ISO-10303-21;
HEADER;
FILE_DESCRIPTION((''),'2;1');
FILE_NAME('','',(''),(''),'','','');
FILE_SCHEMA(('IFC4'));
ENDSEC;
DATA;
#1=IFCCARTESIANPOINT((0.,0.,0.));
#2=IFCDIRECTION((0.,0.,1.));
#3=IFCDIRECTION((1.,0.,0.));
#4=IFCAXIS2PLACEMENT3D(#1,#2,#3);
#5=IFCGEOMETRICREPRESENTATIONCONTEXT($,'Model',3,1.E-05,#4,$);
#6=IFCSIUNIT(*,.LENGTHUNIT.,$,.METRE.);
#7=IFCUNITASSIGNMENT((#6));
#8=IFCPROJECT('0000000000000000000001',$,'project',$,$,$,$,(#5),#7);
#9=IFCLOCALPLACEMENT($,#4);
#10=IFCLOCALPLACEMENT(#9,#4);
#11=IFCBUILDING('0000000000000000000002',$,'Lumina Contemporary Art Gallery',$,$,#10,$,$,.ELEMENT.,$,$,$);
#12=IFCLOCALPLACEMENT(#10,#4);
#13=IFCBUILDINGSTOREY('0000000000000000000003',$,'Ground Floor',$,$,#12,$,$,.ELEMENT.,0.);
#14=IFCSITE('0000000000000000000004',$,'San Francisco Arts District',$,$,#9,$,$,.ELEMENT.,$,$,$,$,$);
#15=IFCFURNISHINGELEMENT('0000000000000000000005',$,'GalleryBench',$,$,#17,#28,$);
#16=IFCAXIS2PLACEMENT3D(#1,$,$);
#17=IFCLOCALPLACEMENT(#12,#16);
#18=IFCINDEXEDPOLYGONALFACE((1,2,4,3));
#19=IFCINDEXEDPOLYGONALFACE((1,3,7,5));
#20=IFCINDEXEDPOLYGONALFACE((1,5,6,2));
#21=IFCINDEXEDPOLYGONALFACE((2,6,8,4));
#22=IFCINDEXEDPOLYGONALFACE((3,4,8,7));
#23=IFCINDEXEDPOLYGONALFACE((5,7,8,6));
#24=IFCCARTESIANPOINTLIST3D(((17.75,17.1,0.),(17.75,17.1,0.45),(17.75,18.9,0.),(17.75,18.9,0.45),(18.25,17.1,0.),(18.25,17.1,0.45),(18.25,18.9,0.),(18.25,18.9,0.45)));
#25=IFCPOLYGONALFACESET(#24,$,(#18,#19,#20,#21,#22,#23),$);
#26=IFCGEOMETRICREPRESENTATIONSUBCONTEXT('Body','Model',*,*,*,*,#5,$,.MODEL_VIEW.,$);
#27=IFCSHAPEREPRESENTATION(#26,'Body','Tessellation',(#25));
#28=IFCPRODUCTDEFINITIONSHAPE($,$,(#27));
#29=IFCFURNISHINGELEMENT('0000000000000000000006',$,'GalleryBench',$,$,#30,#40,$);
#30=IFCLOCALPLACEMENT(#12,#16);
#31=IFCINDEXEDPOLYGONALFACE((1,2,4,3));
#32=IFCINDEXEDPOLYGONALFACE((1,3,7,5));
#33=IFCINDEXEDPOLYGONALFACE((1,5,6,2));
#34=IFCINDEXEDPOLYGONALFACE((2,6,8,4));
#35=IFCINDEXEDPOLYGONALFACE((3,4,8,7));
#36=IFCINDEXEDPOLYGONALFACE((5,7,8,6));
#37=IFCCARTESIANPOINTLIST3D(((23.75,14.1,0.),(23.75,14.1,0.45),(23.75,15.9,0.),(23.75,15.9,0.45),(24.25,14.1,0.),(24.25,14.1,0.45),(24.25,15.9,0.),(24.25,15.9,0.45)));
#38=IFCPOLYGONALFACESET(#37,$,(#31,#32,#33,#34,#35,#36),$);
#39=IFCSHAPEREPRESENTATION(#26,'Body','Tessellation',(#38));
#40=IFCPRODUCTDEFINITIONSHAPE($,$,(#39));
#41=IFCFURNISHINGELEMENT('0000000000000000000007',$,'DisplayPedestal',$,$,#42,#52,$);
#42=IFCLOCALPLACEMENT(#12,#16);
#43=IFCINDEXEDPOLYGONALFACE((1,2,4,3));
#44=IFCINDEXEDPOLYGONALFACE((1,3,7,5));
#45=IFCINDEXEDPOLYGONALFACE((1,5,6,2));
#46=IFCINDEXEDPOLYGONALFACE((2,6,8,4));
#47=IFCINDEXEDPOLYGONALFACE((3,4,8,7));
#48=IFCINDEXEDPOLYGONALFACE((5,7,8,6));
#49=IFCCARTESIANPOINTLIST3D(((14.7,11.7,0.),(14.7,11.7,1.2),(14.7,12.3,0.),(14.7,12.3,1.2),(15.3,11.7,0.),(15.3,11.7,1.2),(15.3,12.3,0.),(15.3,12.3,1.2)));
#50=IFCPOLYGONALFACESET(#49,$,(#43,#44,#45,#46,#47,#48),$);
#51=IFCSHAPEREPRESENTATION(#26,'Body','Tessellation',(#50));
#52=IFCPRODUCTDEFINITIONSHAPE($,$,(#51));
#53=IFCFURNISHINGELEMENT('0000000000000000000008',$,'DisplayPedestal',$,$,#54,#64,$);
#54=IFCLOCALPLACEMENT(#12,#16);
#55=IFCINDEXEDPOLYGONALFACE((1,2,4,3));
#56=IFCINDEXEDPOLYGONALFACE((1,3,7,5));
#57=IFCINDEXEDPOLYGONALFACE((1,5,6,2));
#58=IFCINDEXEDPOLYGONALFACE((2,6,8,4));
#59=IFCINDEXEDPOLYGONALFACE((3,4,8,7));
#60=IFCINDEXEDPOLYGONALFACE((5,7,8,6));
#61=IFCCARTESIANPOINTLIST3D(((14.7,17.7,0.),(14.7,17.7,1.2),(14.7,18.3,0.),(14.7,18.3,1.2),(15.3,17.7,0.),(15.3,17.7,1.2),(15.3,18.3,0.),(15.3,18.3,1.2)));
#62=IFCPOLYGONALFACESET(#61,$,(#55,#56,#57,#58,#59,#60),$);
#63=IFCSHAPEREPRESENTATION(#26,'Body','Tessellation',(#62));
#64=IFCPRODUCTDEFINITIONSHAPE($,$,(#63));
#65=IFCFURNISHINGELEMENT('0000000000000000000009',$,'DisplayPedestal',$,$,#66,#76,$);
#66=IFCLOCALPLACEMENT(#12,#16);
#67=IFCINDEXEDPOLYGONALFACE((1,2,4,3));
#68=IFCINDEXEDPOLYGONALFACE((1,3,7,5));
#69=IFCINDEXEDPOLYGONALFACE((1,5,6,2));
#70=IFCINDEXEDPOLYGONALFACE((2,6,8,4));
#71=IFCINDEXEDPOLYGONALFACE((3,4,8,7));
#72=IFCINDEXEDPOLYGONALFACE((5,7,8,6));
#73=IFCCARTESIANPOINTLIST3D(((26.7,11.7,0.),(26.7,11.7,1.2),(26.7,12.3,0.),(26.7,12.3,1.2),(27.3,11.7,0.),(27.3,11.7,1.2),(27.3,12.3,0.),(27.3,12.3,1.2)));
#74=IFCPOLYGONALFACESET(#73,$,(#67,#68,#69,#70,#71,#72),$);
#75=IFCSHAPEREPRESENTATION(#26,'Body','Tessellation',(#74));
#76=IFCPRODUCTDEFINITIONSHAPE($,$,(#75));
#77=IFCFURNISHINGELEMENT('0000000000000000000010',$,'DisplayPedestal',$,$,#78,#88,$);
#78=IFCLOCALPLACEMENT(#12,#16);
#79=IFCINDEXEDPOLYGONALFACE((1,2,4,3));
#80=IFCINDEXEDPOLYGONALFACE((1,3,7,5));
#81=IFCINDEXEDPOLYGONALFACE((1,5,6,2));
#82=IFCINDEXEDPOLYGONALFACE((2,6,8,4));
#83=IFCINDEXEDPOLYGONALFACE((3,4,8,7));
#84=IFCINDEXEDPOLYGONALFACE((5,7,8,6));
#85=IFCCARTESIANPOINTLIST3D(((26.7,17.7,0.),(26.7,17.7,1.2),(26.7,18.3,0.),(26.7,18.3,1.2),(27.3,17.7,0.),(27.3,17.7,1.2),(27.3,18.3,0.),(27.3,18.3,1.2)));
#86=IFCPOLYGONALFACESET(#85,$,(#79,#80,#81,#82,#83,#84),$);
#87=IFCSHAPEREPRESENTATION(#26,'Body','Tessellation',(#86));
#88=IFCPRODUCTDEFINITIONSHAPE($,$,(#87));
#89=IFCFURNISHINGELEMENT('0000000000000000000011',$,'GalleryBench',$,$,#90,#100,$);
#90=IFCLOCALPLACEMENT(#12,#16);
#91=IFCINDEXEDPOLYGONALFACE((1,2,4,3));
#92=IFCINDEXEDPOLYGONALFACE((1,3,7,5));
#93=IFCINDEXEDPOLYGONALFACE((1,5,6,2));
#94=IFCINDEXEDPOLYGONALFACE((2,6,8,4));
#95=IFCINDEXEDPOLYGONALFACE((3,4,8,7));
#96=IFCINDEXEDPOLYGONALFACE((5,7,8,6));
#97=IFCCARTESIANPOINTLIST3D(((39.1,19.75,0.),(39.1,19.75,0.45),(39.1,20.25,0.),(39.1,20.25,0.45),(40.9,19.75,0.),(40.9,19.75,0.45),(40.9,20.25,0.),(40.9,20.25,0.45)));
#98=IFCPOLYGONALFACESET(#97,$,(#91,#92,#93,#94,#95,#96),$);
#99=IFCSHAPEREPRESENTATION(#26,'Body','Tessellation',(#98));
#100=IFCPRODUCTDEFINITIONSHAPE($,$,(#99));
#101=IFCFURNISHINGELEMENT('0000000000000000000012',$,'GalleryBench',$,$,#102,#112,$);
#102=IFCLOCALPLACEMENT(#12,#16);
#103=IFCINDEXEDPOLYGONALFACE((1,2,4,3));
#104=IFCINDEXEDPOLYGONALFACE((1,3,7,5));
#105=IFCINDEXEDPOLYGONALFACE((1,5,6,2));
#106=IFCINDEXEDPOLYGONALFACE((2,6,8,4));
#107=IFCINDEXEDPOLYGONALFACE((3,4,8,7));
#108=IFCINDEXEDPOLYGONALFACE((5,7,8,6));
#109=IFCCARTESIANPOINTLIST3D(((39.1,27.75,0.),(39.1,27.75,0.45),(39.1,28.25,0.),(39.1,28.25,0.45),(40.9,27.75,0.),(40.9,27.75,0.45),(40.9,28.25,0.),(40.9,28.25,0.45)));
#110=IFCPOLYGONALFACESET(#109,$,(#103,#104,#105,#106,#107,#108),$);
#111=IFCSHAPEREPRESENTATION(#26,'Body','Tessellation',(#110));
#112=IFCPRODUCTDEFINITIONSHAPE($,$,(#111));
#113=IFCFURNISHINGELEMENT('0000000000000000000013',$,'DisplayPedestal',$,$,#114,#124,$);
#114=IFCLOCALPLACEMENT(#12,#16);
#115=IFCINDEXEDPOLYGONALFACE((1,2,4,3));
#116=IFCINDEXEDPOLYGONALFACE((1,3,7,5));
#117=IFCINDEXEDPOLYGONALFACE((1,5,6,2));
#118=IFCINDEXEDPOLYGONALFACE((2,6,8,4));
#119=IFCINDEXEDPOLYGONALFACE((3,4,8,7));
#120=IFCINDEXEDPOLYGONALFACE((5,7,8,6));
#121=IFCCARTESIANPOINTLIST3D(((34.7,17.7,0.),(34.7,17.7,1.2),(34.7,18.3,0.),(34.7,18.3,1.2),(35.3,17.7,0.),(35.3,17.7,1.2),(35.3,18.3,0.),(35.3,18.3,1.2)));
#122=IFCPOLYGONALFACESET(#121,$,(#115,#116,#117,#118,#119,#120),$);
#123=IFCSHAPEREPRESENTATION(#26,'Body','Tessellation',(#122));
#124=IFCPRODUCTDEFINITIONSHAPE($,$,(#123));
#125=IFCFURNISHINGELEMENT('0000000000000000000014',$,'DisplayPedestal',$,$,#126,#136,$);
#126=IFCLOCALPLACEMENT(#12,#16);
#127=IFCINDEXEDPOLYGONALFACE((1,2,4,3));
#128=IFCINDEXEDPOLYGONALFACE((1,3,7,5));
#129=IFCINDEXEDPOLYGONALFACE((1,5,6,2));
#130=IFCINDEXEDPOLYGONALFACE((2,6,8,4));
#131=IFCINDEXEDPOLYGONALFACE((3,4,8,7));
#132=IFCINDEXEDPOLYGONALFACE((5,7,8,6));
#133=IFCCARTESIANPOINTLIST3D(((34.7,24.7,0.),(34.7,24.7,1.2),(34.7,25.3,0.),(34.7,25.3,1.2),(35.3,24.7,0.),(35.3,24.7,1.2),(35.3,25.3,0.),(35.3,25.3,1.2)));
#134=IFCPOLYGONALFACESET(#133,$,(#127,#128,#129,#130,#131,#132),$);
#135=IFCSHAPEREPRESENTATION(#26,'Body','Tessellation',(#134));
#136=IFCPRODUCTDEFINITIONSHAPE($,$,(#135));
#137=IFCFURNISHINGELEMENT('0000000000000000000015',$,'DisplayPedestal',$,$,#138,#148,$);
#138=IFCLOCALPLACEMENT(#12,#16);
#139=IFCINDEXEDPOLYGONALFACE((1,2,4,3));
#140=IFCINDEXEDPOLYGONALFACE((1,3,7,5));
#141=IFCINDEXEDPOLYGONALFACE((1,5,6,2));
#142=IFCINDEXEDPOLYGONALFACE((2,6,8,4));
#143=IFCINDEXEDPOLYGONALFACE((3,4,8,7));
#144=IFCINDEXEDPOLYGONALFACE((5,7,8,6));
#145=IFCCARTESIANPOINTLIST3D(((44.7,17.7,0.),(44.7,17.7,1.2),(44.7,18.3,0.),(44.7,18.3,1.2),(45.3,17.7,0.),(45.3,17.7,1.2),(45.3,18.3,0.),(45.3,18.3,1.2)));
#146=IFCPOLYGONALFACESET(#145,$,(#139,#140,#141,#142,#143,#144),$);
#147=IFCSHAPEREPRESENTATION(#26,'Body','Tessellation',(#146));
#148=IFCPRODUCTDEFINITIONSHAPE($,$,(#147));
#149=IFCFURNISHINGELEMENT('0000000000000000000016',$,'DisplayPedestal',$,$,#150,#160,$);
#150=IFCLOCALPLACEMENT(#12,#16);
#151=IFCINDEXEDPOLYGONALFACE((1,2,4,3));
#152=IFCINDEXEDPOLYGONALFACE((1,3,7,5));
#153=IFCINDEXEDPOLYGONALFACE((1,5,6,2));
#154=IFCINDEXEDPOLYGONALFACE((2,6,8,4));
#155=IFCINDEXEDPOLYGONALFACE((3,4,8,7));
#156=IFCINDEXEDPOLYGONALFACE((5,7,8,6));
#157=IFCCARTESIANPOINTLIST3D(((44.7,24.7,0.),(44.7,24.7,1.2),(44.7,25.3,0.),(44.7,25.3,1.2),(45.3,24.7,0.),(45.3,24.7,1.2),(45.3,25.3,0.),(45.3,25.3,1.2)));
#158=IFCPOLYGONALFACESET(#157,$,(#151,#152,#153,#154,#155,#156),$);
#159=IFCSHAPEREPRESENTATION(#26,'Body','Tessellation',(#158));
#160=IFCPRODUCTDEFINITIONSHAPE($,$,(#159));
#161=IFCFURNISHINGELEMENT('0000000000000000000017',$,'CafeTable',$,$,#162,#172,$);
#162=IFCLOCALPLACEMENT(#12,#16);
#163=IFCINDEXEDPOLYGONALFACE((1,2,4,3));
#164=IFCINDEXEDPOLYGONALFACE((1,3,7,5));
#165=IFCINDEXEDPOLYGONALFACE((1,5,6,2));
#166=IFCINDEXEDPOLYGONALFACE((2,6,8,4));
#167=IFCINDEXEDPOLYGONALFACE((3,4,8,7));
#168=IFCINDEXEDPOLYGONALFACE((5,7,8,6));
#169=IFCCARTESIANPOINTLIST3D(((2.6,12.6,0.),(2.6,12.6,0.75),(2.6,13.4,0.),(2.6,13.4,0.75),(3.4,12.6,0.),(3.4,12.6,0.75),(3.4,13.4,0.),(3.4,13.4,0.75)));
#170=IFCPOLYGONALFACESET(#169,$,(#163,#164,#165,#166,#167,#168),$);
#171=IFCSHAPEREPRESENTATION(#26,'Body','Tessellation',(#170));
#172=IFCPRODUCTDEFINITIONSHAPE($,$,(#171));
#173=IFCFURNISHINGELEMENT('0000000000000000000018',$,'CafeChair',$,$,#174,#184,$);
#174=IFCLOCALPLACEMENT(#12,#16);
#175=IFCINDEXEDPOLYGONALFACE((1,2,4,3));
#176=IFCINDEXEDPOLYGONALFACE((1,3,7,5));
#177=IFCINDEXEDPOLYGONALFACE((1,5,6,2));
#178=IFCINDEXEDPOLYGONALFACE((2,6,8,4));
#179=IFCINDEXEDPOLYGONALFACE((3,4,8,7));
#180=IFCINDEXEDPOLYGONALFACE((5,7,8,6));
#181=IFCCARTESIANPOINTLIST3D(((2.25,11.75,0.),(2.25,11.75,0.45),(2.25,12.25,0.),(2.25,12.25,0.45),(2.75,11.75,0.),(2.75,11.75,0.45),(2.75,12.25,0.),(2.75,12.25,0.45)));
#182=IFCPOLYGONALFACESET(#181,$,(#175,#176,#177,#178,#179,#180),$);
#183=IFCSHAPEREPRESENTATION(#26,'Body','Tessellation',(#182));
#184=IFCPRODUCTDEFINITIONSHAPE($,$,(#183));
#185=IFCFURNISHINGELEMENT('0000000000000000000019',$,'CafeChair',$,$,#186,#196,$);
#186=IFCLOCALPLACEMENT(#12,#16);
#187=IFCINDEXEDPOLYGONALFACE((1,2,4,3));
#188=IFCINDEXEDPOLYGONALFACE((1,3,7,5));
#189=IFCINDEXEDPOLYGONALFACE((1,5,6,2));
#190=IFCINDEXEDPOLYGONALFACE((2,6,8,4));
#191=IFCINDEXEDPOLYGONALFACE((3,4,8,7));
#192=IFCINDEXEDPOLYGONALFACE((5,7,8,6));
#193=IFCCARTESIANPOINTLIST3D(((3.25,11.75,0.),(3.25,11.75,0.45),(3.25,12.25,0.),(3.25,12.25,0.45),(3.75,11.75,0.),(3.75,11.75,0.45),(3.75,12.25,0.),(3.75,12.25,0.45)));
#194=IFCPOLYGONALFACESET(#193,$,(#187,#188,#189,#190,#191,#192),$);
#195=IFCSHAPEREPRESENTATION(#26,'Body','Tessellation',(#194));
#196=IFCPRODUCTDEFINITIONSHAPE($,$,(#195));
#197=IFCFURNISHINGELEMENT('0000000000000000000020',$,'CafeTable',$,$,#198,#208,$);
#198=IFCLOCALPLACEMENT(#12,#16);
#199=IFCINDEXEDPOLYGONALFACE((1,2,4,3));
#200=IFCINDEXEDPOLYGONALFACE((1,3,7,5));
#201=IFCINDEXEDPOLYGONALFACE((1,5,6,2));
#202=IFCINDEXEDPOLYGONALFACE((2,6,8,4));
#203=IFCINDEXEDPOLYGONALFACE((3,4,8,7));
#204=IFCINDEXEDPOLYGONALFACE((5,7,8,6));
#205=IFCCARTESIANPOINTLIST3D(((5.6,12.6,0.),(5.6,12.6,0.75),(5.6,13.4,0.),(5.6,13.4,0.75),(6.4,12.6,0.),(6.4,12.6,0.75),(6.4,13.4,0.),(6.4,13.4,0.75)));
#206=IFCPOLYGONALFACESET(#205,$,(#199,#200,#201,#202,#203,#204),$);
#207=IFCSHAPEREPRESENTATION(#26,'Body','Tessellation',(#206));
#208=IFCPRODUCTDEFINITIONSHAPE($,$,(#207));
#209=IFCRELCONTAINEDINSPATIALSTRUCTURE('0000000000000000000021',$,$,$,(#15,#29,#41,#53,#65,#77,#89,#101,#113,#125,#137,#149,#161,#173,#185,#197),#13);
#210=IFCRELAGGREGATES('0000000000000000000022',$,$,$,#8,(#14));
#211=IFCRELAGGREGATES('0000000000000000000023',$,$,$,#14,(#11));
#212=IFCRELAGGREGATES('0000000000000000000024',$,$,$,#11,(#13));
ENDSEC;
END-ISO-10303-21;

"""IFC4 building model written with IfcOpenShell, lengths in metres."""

from ifc_helpers import new_model, si_unit, origin_with_axes, place, context, subcontext, project, spatial, polyline, outline, extrude, element, save


model = new_model("IFC4")

# Units and contexts
model_context = context("Model", 3, precision=1e-05, world=origin_with_axes())
body_context = subcontext(model_context, "Body", "Model", "MODEL_VIEW")
ifc_project = project(units=[si_unit("LENGTHUNIT", "METRE")], contexts=[model_context])

# Site, building, storey
site_placement = place(None, origin_with_axes())
site = spatial("IfcSite", under=ifc_project, at=site_placement, Name="San Francisco Arts District", CompositionType="ELEMENT")
building_placement = place(site_placement, origin_with_axes())
building = spatial("IfcBuilding", under=site, at=building_placement, Name="Lumina Contemporary Art Gallery", CompositionType="ELEMENT")
storey_placement = place(building_placement, origin_with_axes())
storey = spatial("IfcBuildingStorey", under=building, at=storey_placement, Name="Ground Floor", CompositionType="ELEMENT", Elevation=0.0)

# Furnishing elements
furnishing_1_placement = place(storey_placement, origin_with_axes())
element("IfcFurnishingElement", 1, at=furnishing_1_placement, inside=storey, Name="GalleryBench", context=body_context, shape_type="SweptSolid", body=[
    extrude(outline(polyline([(17.75, 18.9, 0.0), (17.75, 17.1, 0.0), (18.25, 17.1, 0.0), (18.25, 18.9, 0.0), (17.75, 18.9, 0.0)])), None, (0.0, 0.0, 1.0), 0.45),
])
furnishing_2_placement = place(storey_placement, origin_with_axes())
element("IfcFurnishingElement", 2, at=furnishing_2_placement, inside=storey, Name="GalleryBench", context=body_context, shape_type="SweptSolid", body=[
    extrude(outline(polyline([(24.25, 14.1, 0.0), (24.25, 15.9, 0.0), (23.75, 15.9, 0.0), (23.75, 14.1, 0.0), (24.25, 14.1, 0.0)])), None, (0.0, 0.0, 1.0), 0.45),
])
furnishing_3_placement = place(storey_placement, origin_with_axes())
element("IfcFurnishingElement", 3, at=furnishing_3_placement, inside=storey, Name="DisplayPedestal", context=body_context, shape_type="SweptSolid", body=[
    extrude(outline(polyline([(14.7, 11.7, 0.0), (15.3, 11.7, 0.0), (15.3, 12.3, 0.0), (14.7, 12.3, 0.0), (14.7, 11.7, 0.0)])), None, (0.0, 0.0, 1.0), 1.2),
])
furnishing_4_placement = place(storey_placement, origin_with_axes())
element("IfcFurnishingElement", 4, at=furnishing_4_placement, inside=storey, Name="DisplayPedestal", context=body_context, shape_type="SweptSolid", body=[
    extrude(outline(polyline([(14.7, 17.7, 0.0), (15.3, 17.7, 0.0), (15.3, 18.3, 0.0), (14.7, 18.3, 0.0), (14.7, 17.7, 0.0)])), None, (0.0, 0.0, 1.0), 1.2),
])
furnishing_5_placement = place(storey_placement, origin_with_axes())
element("IfcFurnishingElement", 5, at=furnishing_5_placement, inside=storey, Name="DisplayPedestal", context=body_context, shape_type="SweptSolid", body=[
    extrude(outline(polyline([(27.3, 12.3, 0.0), (26.7, 12.3, 0.0), (26.7, 11.7, 0.0), (27.3, 11.7, 0.0), (27.3, 12.3, 0.0)])), None, (0.0, 0.0, 1.0), 1.2),
])
furnishing_6_placement = place(storey_placement, origin_with_axes())
element("IfcFurnishingElement", 6, at=furnishing_6_placement, inside=storey, Name="DisplayPedestal", context=body_context, shape_type="SweptSolid", body=[
    extrude(outline(polyline([(27.3, 18.3, 0.0), (26.7, 18.3, 0.0), (26.7, 17.7, 0.0), (27.3, 17.7, 0.0), (27.3, 18.3, 0.0)])), None, (0.0, 0.0, 1.0), 1.2),
])
furnishing_7_placement = place(storey_placement, origin_with_axes())
element("IfcFurnishingElement", 7, at=furnishing_7_placement, inside=storey, Name="GalleryBench", context=body_context, shape_type="SweptSolid", body=[
    extrude(outline(polyline([(40.9, 20.25, 0.0), (39.1, 20.25, 0.0), (39.1, 19.75, 0.0), (40.9, 19.75, 0.0), (40.9, 20.25, 0.0)])), None, (0.0, 0.0, 1.0), 0.45),
])
furnishing_8_placement = place(storey_placement, origin_with_axes())
element("IfcFurnishingElement", 8, at=furnishing_8_placement, inside=storey, Name="GalleryBench", context=body_context, shape_type="SweptSolid", body=[
    extrude(outline(polyline([(40.9, 28.25, 0.0), (39.1, 28.25, 0.0), (39.1, 27.75, 0.0), (40.9, 27.75, 0.0), (40.9, 28.25, 0.0)])), None, (0.0, 0.0, 1.0), 0.45),
])
furnishing_9_placement = place(storey_placement, origin_with_axes())
element("IfcFurnishingElement", 9, at=furnishing_9_placement, inside=storey, Name="DisplayPedestal", context=body_context, shape_type="SweptSolid", body=[
    extrude(outline(polyline([(34.7, 18.3, 0.0), (34.7, 17.7, 0.0), (35.3, 17.7, 0.0), (35.3, 18.3, 0.0), (34.7, 18.3, 0.0)])), None, (0.0, 0.0, 1.0), 1.2),
])
furnishing_10_placement = place(storey_placement, origin_with_axes())
element("IfcFurnishingElement", 10, at=furnishing_10_placement, inside=storey, Name="DisplayPedestal", context=body_context, shape_type="SweptSolid", body=[
    extrude(outline(polyline([(34.7, 25.3, 0.0), (34.7, 24.7, 0.0), (35.3, 24.7, 0.0), (35.3, 25.3, 0.0), (34.7, 25.3, 0.0)])), None, (0.0, 0.0, 1.0), 1.2),
])
furnishing_11_placement = place(storey_placement, origin_with_axes())
element("IfcFurnishingElement", 11, at=furnishing_11_placement, inside=storey, Name="DisplayPedestal", context=body_context, shape_type="SweptSolid", body=[
    extrude(outline(polyline([(45.3, 17.7, 0.0), (45.3, 18.3, 0.0), (44.7, 18.3, 0.0), (44.7, 17.7, 0.0), (45.3, 17.7, 0.0)])), None, (0.0, 0.0, 1.0), 1.2),
])
furnishing_12_placement = place(storey_placement, origin_with_axes())
element("IfcFurnishingElement", 12, at=furnishing_12_placement, inside=storey, Name="DisplayPedestal", context=body_context, shape_type="SweptSolid", body=[
    extrude(outline(polyline([(45.3, 24.7, 0.0), (45.3, 25.3, 0.0), (44.7, 25.3, 0.0), (44.7, 24.7, 0.0), (45.3, 24.7, 0.0)])), None, (0.0, 0.0, 1.0), 1.2),
])
furnishing_13_placement = place(storey_placement, origin_with_axes())
element("IfcFurnishingElement", 13, at=furnishing_13_placement, inside=storey, Name="CafeTable", context=body_context, shape_type="SweptSolid", body=[
    extrude(outline(polyline([(2.6, 12.6, 0.0), (3.4, 12.6, 0.0), (3.4, 13.4, 0.0), (2.6, 13.4, 0.0), (2.6, 12.6, 0.0)])), None, (0.0, 0.0, 1.0), 0.75),
])
furnishing_14_placement = place(storey_placement, origin_with_axes())
element("IfcFurnishingElement", 14, at=furnishing_14_placement, inside=storey, Name="CafeChair", context=body_context, shape_type="SweptSolid", body=[
    extrude(outline(polyline([(2.25, 11.75, 0.0), (2.75, 11.75, 0.0), (2.75, 12.25, 0.0), (2.25, 12.25, 0.0), (2.25, 11.75, 0.0)])), None, (0.0, 0.0, 1.0), 0.45),
])
furnishing_15_placement = place(storey_placement, origin_with_axes())
element("IfcFurnishingElement", 15, at=furnishing_15_placement, inside=storey, Name="CafeChair", context=body_context, shape_type="SweptSolid", body=[
    extrude(outline(polyline([(3.25, 11.75, 0.0), (3.75, 11.75, 0.0), (3.75, 12.25, 0.0), (3.25, 12.25, 0.0), (3.25, 11.75, 0.0)])), None, (0.0, 0.0, 1.0), 0.45),
])
furnishing_16_placement = place(storey_placement, origin_with_axes())
element("IfcFurnishingElement", 16, at=furnishing_16_placement, inside=storey, Name="CafeTable", context=body_context, shape_type="SweptSolid", body=[
    extrude(outline(polyline([(5.6, 12.6, 0.0), (6.4, 12.6, 0.0), (6.4, 13.4, 0.0), (5.6, 13.4, 0.0), (5.6, 12.6, 0.0)])), None, (0.0, 0.0, 1.0), 0.75),
])

save(model, "model.ifc")
